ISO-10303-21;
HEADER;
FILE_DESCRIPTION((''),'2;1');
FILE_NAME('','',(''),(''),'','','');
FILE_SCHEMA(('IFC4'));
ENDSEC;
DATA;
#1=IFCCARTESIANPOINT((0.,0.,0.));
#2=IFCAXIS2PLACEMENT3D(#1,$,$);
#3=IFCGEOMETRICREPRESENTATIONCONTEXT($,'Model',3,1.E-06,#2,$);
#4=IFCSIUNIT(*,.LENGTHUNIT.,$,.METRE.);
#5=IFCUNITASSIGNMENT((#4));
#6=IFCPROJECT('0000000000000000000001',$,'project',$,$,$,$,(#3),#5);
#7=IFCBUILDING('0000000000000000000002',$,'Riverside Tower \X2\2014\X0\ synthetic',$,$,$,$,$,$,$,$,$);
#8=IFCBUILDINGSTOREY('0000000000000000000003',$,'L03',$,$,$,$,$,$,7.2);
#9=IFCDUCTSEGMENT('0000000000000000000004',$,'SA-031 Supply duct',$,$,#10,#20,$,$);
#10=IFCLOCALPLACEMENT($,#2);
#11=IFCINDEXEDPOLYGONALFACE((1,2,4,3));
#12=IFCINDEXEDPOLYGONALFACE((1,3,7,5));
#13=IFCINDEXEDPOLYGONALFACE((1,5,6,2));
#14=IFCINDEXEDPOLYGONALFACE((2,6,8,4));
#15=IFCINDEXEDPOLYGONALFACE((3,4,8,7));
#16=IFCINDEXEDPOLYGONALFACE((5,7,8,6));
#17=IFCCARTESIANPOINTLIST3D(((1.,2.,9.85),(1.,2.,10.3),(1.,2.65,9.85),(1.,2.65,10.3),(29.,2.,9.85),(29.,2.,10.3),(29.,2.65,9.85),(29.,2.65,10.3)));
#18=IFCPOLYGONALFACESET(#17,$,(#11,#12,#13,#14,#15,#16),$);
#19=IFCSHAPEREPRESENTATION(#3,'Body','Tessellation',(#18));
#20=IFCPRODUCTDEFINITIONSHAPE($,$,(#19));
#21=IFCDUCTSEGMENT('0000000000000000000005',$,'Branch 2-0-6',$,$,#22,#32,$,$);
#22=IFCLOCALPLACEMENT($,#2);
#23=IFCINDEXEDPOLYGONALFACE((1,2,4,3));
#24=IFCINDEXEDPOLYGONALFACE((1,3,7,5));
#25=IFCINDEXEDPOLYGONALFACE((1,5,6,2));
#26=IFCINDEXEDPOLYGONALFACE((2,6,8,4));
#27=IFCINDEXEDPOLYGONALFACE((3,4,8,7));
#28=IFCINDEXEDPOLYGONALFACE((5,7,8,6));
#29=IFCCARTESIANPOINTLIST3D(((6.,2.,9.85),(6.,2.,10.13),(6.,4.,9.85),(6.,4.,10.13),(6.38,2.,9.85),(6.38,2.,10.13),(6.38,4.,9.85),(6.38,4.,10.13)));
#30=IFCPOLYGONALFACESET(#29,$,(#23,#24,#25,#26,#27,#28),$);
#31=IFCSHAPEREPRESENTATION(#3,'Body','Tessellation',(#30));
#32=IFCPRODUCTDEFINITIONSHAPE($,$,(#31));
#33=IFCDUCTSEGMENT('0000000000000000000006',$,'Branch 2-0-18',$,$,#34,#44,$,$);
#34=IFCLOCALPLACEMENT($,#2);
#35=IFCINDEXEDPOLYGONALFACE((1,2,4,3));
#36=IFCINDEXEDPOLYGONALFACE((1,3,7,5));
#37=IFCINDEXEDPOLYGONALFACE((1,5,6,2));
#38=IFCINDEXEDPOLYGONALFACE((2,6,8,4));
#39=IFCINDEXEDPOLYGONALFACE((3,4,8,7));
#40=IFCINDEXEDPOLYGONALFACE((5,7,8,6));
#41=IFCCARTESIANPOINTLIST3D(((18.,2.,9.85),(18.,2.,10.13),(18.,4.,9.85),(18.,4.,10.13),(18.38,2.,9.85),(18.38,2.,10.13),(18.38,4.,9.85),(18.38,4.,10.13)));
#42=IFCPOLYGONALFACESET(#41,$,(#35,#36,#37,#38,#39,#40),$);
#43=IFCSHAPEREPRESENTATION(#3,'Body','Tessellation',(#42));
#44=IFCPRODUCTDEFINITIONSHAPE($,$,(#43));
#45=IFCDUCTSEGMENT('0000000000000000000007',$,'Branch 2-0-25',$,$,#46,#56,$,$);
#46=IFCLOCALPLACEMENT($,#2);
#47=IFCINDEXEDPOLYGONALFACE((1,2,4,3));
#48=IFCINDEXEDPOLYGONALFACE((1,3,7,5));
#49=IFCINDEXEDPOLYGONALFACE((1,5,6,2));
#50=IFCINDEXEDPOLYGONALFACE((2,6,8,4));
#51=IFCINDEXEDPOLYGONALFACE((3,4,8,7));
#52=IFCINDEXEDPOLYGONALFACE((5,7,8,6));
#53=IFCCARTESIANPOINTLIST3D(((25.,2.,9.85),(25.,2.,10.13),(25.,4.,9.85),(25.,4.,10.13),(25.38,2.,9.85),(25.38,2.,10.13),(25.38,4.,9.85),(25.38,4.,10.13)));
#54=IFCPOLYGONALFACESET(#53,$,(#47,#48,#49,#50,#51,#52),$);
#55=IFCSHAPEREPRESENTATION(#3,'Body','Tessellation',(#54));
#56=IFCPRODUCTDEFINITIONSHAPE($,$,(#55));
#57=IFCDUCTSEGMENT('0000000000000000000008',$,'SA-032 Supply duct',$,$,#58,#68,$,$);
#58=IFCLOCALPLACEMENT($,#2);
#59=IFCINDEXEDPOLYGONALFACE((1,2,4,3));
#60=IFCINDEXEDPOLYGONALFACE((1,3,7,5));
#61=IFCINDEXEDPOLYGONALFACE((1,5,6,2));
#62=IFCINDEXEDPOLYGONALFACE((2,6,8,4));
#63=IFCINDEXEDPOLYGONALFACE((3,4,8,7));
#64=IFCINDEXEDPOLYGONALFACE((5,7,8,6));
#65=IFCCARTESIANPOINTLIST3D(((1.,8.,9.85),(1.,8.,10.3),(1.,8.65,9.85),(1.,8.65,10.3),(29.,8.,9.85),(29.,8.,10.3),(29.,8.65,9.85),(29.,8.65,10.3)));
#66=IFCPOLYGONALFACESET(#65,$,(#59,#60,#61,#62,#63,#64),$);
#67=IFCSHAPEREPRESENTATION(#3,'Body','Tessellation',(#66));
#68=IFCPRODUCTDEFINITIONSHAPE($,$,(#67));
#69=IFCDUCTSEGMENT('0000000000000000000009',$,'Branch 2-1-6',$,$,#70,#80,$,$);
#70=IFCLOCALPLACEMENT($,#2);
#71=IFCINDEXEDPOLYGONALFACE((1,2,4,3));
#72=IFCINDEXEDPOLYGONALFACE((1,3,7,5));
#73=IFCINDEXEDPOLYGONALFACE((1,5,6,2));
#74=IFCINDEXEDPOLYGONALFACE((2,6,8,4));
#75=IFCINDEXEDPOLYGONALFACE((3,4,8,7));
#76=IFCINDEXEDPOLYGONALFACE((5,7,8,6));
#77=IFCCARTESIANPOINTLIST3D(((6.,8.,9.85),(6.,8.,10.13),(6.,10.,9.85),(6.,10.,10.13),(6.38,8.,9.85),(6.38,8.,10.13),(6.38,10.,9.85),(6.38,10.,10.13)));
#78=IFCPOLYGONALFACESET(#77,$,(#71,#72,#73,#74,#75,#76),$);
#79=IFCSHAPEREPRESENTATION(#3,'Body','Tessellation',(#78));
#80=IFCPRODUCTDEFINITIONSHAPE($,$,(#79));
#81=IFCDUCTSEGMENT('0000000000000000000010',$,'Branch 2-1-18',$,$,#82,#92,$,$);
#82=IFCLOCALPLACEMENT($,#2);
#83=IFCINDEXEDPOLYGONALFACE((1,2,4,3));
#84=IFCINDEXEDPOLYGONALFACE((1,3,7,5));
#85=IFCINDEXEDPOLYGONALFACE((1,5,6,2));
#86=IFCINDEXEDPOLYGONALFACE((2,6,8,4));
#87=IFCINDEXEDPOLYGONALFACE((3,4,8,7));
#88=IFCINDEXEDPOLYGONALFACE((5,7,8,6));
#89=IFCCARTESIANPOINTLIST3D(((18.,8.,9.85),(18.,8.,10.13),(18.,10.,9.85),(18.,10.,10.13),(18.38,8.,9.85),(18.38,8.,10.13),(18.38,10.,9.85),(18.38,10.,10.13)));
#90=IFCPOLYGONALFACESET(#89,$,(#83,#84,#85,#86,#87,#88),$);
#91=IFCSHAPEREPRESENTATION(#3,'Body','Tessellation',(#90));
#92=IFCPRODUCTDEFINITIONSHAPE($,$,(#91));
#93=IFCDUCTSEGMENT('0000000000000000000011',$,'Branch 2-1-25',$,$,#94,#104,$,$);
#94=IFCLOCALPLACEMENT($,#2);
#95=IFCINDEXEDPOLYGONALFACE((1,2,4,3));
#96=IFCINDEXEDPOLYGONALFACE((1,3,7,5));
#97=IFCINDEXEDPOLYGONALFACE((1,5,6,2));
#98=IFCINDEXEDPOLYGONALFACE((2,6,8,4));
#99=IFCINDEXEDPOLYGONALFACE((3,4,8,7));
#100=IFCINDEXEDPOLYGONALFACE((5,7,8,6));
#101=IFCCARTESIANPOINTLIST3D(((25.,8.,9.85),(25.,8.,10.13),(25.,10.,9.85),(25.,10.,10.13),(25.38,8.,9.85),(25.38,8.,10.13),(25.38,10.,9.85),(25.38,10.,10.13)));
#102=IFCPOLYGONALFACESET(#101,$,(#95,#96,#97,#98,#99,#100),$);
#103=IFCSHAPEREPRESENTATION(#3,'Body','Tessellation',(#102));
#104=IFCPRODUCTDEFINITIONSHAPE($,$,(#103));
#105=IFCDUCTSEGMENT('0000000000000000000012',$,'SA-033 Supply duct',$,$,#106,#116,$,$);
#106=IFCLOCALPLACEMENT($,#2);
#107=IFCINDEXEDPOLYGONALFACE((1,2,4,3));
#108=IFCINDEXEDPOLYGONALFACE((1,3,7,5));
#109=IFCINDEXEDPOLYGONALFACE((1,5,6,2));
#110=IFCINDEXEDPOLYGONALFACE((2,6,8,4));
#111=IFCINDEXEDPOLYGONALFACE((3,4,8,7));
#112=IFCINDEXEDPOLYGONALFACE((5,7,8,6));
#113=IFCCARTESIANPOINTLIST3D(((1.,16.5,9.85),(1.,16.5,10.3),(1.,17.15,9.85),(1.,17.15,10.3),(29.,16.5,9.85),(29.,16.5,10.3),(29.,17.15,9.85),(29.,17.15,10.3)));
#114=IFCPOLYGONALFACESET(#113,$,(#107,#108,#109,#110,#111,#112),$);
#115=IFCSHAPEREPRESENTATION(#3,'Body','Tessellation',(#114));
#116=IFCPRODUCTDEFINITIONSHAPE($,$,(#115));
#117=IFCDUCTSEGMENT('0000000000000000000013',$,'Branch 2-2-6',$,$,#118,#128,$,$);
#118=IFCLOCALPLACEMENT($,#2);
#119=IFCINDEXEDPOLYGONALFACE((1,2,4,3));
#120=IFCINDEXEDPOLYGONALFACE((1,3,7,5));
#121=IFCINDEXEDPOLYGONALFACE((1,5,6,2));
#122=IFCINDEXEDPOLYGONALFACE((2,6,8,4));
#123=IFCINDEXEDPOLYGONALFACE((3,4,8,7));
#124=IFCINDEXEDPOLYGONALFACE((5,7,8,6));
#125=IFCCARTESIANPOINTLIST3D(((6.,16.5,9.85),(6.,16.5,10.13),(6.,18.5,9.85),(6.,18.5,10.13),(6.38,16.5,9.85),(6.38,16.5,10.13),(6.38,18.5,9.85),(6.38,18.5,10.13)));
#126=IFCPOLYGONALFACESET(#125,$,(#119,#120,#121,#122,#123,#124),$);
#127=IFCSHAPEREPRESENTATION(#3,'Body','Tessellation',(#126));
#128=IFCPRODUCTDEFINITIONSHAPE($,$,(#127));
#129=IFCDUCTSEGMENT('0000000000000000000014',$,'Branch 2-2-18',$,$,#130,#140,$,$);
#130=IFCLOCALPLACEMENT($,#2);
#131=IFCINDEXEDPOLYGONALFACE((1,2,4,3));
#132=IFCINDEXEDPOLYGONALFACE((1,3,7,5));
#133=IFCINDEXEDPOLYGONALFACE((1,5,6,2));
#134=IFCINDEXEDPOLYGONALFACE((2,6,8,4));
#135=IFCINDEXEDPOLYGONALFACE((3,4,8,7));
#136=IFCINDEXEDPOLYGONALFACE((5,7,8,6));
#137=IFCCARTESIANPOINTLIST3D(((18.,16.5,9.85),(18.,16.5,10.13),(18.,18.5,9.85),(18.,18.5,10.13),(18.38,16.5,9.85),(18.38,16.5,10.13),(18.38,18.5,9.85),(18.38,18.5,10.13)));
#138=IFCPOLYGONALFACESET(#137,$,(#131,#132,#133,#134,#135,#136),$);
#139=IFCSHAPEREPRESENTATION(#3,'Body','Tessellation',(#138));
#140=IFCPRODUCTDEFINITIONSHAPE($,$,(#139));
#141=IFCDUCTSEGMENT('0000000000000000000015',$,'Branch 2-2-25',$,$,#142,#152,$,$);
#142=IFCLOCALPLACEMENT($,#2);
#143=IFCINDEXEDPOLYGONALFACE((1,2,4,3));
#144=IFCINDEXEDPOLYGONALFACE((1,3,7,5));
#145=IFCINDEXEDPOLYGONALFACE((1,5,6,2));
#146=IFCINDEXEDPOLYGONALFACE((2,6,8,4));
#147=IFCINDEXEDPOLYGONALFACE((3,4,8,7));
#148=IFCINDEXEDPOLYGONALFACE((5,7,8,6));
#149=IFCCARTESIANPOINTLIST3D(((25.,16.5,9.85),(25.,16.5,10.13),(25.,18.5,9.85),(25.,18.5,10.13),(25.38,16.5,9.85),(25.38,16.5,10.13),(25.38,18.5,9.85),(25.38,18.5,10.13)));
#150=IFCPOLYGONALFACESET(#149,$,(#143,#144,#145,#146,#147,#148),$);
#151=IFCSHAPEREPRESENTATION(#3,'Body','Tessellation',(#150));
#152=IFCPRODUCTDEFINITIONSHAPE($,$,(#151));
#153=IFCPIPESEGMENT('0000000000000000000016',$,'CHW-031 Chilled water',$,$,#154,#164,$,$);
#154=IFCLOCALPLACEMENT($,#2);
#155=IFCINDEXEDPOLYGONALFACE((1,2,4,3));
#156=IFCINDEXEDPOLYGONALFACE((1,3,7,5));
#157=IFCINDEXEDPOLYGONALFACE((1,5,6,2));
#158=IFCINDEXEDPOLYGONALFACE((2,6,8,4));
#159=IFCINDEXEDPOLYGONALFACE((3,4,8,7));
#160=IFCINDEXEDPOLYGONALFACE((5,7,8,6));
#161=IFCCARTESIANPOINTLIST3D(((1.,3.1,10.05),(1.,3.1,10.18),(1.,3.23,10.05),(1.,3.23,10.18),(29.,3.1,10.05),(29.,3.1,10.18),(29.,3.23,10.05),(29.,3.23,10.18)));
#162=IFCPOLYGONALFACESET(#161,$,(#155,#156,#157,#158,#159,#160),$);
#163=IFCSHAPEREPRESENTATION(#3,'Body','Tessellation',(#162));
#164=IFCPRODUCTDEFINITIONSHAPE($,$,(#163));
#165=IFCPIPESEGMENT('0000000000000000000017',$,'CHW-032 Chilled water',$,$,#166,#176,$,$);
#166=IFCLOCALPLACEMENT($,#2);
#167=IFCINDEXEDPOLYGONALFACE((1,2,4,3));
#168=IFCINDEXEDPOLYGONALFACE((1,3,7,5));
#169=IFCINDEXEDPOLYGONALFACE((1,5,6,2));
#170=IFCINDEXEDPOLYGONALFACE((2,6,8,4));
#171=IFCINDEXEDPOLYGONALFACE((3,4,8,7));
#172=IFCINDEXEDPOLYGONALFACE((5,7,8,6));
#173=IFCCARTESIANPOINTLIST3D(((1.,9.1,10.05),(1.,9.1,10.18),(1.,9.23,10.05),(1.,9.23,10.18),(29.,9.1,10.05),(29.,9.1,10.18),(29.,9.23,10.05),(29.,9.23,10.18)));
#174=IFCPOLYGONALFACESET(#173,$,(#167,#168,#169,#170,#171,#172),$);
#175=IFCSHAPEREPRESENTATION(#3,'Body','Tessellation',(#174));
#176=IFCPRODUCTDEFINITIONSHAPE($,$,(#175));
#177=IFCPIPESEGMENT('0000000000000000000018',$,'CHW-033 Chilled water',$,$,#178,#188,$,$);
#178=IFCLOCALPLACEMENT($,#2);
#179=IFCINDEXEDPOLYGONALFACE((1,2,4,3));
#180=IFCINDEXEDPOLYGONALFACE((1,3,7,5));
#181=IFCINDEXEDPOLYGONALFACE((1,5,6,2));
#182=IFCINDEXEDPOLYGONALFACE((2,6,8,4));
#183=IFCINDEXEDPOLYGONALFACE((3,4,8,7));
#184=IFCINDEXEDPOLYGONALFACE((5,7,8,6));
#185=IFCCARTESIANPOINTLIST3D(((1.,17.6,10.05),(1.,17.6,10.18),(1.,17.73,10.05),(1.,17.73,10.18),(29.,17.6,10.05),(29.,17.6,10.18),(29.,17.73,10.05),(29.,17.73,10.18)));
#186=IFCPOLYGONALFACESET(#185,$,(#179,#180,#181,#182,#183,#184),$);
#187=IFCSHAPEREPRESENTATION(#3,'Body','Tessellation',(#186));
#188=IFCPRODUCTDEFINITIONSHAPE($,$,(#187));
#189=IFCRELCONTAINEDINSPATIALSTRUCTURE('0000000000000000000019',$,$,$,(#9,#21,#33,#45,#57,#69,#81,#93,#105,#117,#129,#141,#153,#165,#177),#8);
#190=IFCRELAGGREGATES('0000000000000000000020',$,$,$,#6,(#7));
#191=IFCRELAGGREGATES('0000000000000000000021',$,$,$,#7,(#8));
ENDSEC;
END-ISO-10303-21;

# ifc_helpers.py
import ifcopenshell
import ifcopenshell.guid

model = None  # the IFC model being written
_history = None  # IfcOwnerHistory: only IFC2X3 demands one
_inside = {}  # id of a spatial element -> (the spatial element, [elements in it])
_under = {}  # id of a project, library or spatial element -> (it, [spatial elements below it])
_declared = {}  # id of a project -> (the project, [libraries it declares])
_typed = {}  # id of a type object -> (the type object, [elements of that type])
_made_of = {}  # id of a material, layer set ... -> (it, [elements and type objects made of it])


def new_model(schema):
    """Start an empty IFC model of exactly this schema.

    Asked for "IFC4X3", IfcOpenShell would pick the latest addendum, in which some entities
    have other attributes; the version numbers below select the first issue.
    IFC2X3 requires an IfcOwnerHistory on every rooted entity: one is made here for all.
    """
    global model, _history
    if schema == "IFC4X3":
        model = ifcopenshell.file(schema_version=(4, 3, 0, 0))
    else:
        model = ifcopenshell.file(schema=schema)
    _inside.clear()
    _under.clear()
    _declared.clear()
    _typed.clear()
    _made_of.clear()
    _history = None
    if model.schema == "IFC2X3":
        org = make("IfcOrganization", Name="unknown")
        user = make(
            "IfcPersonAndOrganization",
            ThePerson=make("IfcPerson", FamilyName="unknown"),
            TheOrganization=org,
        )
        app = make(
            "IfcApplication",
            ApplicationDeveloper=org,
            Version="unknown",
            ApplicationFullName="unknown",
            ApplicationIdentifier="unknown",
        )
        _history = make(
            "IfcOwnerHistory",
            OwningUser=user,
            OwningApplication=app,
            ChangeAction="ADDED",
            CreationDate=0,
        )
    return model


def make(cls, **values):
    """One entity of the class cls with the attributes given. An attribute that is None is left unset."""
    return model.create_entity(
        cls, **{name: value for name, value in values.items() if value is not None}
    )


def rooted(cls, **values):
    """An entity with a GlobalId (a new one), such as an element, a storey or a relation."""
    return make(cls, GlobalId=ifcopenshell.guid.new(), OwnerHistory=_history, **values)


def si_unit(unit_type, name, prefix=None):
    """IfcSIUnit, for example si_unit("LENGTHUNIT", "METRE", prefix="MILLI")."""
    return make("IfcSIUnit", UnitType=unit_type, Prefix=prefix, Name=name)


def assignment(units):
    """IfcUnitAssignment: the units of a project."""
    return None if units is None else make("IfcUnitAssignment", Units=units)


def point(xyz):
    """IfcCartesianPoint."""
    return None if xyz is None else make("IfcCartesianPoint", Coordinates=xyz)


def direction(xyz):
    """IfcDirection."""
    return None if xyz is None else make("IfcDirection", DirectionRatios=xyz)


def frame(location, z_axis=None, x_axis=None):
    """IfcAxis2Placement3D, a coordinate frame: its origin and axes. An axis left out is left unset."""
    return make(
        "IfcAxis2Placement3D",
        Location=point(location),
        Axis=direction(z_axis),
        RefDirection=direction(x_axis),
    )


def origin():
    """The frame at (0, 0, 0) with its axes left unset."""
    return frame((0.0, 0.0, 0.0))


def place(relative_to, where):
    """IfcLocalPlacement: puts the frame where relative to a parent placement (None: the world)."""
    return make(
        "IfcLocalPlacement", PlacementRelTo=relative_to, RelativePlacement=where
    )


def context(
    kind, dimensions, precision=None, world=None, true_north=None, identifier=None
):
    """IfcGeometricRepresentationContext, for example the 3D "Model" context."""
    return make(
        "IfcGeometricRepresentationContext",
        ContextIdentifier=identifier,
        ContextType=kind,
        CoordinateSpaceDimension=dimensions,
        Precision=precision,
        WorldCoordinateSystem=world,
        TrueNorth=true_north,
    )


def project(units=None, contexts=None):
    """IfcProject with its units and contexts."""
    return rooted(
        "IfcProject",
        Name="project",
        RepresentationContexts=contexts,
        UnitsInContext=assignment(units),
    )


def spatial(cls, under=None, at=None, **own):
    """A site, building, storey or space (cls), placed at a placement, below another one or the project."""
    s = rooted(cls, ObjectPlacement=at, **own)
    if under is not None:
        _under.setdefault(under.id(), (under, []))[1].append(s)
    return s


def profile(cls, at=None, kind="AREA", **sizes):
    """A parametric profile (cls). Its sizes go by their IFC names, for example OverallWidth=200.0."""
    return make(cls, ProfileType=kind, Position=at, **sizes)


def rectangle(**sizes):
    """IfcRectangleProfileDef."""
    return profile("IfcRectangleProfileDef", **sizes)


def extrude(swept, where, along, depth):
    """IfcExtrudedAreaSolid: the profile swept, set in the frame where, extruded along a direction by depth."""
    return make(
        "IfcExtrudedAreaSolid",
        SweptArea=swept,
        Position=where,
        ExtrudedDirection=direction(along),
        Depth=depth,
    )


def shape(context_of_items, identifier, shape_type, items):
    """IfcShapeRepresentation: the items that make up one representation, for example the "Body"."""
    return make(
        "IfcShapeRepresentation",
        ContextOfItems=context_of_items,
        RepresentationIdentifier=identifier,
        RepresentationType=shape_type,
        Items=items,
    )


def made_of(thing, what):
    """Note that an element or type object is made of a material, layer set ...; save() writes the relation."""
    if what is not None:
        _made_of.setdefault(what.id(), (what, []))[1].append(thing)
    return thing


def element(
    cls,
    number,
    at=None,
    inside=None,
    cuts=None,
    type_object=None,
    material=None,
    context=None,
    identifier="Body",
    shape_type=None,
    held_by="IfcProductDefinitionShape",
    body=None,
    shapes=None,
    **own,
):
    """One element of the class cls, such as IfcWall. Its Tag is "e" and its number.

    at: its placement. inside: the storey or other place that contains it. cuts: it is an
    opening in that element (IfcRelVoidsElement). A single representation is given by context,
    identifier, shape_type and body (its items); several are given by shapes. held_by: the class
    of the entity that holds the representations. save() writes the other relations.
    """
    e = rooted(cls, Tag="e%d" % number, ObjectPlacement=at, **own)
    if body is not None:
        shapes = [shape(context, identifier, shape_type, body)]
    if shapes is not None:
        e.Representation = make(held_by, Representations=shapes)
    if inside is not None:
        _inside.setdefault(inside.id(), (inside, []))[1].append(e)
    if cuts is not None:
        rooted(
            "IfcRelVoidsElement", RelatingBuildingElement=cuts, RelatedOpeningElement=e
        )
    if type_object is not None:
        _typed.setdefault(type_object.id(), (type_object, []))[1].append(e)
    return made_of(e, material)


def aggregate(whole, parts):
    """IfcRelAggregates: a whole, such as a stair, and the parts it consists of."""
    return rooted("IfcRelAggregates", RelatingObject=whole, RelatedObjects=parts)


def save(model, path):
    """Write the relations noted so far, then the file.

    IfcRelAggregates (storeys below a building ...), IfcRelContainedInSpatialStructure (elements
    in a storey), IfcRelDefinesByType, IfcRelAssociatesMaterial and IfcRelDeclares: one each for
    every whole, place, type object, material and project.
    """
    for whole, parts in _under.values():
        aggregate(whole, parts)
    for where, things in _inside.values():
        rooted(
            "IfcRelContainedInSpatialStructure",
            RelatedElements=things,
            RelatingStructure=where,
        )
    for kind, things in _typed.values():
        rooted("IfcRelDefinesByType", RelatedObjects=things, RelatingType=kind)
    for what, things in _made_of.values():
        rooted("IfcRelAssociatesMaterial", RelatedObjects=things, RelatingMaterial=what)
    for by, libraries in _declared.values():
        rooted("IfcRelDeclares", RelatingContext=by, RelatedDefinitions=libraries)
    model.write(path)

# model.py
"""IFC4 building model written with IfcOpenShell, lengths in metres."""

from ifc_helpers import new_model, si_unit, frame, origin, place, context, project, spatial, rectangle, extrude, element, save


model = new_model("IFC4")

# Units and contexts
model_context = context("Model", 3, precision=1e-06, world=origin())
ifc_project = project(units=[si_unit("LENGTHUNIT", "METRE")], contexts=[model_context])

# Building, storey
building = spatial("IfcBuilding", under=ifc_project, Name="Riverside Tower — synthetic")
storey = spatial("IfcBuildingStorey", under=building, Name="L03", Elevation=7.2)

# Duct segments
duct_segment_1_placement = place(None, frame((15.0, 2.325, 9.85)))
element("IfcDuctSegment", 1, at=duct_segment_1_placement, inside=storey, Name="SA-031 Supply duct", context=model_context, shape_type="SweptSolid", body=[
    extrude(rectangle(XDim=28.0, YDim=0.65), origin(), (0.0, 0.0, 1.0), 0.45),
])
for number, where, name in (
    (2, (6.19, 3.0, 9.85), "Branch 2-0-6"),
    (3, (18.19, 3.0, 9.85), "Branch 2-0-18"),
    (4, (25.19, 3.0, 9.85), "Branch 2-0-25"),
):
    element("IfcDuctSegment", number, at=place(None, frame(where)), inside=storey, Name=name, context=model_context, shape_type="SweptSolid", body=[
        extrude(rectangle(XDim=0.38, YDim=2.0), origin(), (0.0, 0.0, 1.0), 0.28),
    ])
duct_segment_2_placement = place(None, frame((15.0, 8.325, 9.85)))
element("IfcDuctSegment", 5, at=duct_segment_2_placement, inside=storey, Name="SA-032 Supply duct", context=model_context, shape_type="SweptSolid", body=[
    extrude(rectangle(XDim=28.0, YDim=0.65), origin(), (0.0, 0.0, 1.0), 0.45),
])
for number, where, name in (
    (6, (6.19, 9.0, 9.85), "Branch 2-1-6"),
    (7, (18.19, 9.0, 9.85), "Branch 2-1-18"),
    (8, (25.19, 9.0, 9.85), "Branch 2-1-25"),
):
    element("IfcDuctSegment", number, at=place(None, frame(where)), inside=storey, Name=name, context=model_context, shape_type="SweptSolid", body=[
        extrude(rectangle(XDim=0.38, YDim=2.0), origin(), (0.0, 0.0, 1.0), 0.28),
    ])
duct_segment_3_placement = place(None, frame((15.0, 16.825, 9.85)))
element("IfcDuctSegment", 9, at=duct_segment_3_placement, inside=storey, Name="SA-033 Supply duct", context=model_context, shape_type="SweptSolid", body=[
    extrude(rectangle(XDim=28.0, YDim=0.65), origin(), (0.0, 0.0, 1.0), 0.45),
])
for number, where, name in (
    (10, (6.19, 17.5, 9.85), "Branch 2-2-6"),
    (11, (18.19, 17.5, 9.85), "Branch 2-2-18"),
    (12, (25.19, 17.5, 9.85), "Branch 2-2-25"),
):
    element("IfcDuctSegment", number, at=place(None, frame(where)), inside=storey, Name=name, context=model_context, shape_type="SweptSolid", body=[
        extrude(rectangle(XDim=0.38, YDim=2.0), origin(), (0.0, 0.0, 1.0), 0.28),
    ])

# Pipe segments
for number, where, name in (
    (13, (15.0, 3.165, 10.05), "CHW-031 Chilled water"),
    (14, (15.0, 9.165, 10.05), "CHW-032 Chilled water"),
    (15, (15.0, 17.665, 10.05), "CHW-033 Chilled water"),
):
    element("IfcPipeSegment", number, at=place(None, frame(where)), inside=storey, Name=name, context=model_context, shape_type="SweptSolid", body=[
        extrude(rectangle(XDim=28.0, YDim=0.13), origin(), (0.0, 0.0, 1.0), 0.13),
    ])

save(model, "model.ifc")
